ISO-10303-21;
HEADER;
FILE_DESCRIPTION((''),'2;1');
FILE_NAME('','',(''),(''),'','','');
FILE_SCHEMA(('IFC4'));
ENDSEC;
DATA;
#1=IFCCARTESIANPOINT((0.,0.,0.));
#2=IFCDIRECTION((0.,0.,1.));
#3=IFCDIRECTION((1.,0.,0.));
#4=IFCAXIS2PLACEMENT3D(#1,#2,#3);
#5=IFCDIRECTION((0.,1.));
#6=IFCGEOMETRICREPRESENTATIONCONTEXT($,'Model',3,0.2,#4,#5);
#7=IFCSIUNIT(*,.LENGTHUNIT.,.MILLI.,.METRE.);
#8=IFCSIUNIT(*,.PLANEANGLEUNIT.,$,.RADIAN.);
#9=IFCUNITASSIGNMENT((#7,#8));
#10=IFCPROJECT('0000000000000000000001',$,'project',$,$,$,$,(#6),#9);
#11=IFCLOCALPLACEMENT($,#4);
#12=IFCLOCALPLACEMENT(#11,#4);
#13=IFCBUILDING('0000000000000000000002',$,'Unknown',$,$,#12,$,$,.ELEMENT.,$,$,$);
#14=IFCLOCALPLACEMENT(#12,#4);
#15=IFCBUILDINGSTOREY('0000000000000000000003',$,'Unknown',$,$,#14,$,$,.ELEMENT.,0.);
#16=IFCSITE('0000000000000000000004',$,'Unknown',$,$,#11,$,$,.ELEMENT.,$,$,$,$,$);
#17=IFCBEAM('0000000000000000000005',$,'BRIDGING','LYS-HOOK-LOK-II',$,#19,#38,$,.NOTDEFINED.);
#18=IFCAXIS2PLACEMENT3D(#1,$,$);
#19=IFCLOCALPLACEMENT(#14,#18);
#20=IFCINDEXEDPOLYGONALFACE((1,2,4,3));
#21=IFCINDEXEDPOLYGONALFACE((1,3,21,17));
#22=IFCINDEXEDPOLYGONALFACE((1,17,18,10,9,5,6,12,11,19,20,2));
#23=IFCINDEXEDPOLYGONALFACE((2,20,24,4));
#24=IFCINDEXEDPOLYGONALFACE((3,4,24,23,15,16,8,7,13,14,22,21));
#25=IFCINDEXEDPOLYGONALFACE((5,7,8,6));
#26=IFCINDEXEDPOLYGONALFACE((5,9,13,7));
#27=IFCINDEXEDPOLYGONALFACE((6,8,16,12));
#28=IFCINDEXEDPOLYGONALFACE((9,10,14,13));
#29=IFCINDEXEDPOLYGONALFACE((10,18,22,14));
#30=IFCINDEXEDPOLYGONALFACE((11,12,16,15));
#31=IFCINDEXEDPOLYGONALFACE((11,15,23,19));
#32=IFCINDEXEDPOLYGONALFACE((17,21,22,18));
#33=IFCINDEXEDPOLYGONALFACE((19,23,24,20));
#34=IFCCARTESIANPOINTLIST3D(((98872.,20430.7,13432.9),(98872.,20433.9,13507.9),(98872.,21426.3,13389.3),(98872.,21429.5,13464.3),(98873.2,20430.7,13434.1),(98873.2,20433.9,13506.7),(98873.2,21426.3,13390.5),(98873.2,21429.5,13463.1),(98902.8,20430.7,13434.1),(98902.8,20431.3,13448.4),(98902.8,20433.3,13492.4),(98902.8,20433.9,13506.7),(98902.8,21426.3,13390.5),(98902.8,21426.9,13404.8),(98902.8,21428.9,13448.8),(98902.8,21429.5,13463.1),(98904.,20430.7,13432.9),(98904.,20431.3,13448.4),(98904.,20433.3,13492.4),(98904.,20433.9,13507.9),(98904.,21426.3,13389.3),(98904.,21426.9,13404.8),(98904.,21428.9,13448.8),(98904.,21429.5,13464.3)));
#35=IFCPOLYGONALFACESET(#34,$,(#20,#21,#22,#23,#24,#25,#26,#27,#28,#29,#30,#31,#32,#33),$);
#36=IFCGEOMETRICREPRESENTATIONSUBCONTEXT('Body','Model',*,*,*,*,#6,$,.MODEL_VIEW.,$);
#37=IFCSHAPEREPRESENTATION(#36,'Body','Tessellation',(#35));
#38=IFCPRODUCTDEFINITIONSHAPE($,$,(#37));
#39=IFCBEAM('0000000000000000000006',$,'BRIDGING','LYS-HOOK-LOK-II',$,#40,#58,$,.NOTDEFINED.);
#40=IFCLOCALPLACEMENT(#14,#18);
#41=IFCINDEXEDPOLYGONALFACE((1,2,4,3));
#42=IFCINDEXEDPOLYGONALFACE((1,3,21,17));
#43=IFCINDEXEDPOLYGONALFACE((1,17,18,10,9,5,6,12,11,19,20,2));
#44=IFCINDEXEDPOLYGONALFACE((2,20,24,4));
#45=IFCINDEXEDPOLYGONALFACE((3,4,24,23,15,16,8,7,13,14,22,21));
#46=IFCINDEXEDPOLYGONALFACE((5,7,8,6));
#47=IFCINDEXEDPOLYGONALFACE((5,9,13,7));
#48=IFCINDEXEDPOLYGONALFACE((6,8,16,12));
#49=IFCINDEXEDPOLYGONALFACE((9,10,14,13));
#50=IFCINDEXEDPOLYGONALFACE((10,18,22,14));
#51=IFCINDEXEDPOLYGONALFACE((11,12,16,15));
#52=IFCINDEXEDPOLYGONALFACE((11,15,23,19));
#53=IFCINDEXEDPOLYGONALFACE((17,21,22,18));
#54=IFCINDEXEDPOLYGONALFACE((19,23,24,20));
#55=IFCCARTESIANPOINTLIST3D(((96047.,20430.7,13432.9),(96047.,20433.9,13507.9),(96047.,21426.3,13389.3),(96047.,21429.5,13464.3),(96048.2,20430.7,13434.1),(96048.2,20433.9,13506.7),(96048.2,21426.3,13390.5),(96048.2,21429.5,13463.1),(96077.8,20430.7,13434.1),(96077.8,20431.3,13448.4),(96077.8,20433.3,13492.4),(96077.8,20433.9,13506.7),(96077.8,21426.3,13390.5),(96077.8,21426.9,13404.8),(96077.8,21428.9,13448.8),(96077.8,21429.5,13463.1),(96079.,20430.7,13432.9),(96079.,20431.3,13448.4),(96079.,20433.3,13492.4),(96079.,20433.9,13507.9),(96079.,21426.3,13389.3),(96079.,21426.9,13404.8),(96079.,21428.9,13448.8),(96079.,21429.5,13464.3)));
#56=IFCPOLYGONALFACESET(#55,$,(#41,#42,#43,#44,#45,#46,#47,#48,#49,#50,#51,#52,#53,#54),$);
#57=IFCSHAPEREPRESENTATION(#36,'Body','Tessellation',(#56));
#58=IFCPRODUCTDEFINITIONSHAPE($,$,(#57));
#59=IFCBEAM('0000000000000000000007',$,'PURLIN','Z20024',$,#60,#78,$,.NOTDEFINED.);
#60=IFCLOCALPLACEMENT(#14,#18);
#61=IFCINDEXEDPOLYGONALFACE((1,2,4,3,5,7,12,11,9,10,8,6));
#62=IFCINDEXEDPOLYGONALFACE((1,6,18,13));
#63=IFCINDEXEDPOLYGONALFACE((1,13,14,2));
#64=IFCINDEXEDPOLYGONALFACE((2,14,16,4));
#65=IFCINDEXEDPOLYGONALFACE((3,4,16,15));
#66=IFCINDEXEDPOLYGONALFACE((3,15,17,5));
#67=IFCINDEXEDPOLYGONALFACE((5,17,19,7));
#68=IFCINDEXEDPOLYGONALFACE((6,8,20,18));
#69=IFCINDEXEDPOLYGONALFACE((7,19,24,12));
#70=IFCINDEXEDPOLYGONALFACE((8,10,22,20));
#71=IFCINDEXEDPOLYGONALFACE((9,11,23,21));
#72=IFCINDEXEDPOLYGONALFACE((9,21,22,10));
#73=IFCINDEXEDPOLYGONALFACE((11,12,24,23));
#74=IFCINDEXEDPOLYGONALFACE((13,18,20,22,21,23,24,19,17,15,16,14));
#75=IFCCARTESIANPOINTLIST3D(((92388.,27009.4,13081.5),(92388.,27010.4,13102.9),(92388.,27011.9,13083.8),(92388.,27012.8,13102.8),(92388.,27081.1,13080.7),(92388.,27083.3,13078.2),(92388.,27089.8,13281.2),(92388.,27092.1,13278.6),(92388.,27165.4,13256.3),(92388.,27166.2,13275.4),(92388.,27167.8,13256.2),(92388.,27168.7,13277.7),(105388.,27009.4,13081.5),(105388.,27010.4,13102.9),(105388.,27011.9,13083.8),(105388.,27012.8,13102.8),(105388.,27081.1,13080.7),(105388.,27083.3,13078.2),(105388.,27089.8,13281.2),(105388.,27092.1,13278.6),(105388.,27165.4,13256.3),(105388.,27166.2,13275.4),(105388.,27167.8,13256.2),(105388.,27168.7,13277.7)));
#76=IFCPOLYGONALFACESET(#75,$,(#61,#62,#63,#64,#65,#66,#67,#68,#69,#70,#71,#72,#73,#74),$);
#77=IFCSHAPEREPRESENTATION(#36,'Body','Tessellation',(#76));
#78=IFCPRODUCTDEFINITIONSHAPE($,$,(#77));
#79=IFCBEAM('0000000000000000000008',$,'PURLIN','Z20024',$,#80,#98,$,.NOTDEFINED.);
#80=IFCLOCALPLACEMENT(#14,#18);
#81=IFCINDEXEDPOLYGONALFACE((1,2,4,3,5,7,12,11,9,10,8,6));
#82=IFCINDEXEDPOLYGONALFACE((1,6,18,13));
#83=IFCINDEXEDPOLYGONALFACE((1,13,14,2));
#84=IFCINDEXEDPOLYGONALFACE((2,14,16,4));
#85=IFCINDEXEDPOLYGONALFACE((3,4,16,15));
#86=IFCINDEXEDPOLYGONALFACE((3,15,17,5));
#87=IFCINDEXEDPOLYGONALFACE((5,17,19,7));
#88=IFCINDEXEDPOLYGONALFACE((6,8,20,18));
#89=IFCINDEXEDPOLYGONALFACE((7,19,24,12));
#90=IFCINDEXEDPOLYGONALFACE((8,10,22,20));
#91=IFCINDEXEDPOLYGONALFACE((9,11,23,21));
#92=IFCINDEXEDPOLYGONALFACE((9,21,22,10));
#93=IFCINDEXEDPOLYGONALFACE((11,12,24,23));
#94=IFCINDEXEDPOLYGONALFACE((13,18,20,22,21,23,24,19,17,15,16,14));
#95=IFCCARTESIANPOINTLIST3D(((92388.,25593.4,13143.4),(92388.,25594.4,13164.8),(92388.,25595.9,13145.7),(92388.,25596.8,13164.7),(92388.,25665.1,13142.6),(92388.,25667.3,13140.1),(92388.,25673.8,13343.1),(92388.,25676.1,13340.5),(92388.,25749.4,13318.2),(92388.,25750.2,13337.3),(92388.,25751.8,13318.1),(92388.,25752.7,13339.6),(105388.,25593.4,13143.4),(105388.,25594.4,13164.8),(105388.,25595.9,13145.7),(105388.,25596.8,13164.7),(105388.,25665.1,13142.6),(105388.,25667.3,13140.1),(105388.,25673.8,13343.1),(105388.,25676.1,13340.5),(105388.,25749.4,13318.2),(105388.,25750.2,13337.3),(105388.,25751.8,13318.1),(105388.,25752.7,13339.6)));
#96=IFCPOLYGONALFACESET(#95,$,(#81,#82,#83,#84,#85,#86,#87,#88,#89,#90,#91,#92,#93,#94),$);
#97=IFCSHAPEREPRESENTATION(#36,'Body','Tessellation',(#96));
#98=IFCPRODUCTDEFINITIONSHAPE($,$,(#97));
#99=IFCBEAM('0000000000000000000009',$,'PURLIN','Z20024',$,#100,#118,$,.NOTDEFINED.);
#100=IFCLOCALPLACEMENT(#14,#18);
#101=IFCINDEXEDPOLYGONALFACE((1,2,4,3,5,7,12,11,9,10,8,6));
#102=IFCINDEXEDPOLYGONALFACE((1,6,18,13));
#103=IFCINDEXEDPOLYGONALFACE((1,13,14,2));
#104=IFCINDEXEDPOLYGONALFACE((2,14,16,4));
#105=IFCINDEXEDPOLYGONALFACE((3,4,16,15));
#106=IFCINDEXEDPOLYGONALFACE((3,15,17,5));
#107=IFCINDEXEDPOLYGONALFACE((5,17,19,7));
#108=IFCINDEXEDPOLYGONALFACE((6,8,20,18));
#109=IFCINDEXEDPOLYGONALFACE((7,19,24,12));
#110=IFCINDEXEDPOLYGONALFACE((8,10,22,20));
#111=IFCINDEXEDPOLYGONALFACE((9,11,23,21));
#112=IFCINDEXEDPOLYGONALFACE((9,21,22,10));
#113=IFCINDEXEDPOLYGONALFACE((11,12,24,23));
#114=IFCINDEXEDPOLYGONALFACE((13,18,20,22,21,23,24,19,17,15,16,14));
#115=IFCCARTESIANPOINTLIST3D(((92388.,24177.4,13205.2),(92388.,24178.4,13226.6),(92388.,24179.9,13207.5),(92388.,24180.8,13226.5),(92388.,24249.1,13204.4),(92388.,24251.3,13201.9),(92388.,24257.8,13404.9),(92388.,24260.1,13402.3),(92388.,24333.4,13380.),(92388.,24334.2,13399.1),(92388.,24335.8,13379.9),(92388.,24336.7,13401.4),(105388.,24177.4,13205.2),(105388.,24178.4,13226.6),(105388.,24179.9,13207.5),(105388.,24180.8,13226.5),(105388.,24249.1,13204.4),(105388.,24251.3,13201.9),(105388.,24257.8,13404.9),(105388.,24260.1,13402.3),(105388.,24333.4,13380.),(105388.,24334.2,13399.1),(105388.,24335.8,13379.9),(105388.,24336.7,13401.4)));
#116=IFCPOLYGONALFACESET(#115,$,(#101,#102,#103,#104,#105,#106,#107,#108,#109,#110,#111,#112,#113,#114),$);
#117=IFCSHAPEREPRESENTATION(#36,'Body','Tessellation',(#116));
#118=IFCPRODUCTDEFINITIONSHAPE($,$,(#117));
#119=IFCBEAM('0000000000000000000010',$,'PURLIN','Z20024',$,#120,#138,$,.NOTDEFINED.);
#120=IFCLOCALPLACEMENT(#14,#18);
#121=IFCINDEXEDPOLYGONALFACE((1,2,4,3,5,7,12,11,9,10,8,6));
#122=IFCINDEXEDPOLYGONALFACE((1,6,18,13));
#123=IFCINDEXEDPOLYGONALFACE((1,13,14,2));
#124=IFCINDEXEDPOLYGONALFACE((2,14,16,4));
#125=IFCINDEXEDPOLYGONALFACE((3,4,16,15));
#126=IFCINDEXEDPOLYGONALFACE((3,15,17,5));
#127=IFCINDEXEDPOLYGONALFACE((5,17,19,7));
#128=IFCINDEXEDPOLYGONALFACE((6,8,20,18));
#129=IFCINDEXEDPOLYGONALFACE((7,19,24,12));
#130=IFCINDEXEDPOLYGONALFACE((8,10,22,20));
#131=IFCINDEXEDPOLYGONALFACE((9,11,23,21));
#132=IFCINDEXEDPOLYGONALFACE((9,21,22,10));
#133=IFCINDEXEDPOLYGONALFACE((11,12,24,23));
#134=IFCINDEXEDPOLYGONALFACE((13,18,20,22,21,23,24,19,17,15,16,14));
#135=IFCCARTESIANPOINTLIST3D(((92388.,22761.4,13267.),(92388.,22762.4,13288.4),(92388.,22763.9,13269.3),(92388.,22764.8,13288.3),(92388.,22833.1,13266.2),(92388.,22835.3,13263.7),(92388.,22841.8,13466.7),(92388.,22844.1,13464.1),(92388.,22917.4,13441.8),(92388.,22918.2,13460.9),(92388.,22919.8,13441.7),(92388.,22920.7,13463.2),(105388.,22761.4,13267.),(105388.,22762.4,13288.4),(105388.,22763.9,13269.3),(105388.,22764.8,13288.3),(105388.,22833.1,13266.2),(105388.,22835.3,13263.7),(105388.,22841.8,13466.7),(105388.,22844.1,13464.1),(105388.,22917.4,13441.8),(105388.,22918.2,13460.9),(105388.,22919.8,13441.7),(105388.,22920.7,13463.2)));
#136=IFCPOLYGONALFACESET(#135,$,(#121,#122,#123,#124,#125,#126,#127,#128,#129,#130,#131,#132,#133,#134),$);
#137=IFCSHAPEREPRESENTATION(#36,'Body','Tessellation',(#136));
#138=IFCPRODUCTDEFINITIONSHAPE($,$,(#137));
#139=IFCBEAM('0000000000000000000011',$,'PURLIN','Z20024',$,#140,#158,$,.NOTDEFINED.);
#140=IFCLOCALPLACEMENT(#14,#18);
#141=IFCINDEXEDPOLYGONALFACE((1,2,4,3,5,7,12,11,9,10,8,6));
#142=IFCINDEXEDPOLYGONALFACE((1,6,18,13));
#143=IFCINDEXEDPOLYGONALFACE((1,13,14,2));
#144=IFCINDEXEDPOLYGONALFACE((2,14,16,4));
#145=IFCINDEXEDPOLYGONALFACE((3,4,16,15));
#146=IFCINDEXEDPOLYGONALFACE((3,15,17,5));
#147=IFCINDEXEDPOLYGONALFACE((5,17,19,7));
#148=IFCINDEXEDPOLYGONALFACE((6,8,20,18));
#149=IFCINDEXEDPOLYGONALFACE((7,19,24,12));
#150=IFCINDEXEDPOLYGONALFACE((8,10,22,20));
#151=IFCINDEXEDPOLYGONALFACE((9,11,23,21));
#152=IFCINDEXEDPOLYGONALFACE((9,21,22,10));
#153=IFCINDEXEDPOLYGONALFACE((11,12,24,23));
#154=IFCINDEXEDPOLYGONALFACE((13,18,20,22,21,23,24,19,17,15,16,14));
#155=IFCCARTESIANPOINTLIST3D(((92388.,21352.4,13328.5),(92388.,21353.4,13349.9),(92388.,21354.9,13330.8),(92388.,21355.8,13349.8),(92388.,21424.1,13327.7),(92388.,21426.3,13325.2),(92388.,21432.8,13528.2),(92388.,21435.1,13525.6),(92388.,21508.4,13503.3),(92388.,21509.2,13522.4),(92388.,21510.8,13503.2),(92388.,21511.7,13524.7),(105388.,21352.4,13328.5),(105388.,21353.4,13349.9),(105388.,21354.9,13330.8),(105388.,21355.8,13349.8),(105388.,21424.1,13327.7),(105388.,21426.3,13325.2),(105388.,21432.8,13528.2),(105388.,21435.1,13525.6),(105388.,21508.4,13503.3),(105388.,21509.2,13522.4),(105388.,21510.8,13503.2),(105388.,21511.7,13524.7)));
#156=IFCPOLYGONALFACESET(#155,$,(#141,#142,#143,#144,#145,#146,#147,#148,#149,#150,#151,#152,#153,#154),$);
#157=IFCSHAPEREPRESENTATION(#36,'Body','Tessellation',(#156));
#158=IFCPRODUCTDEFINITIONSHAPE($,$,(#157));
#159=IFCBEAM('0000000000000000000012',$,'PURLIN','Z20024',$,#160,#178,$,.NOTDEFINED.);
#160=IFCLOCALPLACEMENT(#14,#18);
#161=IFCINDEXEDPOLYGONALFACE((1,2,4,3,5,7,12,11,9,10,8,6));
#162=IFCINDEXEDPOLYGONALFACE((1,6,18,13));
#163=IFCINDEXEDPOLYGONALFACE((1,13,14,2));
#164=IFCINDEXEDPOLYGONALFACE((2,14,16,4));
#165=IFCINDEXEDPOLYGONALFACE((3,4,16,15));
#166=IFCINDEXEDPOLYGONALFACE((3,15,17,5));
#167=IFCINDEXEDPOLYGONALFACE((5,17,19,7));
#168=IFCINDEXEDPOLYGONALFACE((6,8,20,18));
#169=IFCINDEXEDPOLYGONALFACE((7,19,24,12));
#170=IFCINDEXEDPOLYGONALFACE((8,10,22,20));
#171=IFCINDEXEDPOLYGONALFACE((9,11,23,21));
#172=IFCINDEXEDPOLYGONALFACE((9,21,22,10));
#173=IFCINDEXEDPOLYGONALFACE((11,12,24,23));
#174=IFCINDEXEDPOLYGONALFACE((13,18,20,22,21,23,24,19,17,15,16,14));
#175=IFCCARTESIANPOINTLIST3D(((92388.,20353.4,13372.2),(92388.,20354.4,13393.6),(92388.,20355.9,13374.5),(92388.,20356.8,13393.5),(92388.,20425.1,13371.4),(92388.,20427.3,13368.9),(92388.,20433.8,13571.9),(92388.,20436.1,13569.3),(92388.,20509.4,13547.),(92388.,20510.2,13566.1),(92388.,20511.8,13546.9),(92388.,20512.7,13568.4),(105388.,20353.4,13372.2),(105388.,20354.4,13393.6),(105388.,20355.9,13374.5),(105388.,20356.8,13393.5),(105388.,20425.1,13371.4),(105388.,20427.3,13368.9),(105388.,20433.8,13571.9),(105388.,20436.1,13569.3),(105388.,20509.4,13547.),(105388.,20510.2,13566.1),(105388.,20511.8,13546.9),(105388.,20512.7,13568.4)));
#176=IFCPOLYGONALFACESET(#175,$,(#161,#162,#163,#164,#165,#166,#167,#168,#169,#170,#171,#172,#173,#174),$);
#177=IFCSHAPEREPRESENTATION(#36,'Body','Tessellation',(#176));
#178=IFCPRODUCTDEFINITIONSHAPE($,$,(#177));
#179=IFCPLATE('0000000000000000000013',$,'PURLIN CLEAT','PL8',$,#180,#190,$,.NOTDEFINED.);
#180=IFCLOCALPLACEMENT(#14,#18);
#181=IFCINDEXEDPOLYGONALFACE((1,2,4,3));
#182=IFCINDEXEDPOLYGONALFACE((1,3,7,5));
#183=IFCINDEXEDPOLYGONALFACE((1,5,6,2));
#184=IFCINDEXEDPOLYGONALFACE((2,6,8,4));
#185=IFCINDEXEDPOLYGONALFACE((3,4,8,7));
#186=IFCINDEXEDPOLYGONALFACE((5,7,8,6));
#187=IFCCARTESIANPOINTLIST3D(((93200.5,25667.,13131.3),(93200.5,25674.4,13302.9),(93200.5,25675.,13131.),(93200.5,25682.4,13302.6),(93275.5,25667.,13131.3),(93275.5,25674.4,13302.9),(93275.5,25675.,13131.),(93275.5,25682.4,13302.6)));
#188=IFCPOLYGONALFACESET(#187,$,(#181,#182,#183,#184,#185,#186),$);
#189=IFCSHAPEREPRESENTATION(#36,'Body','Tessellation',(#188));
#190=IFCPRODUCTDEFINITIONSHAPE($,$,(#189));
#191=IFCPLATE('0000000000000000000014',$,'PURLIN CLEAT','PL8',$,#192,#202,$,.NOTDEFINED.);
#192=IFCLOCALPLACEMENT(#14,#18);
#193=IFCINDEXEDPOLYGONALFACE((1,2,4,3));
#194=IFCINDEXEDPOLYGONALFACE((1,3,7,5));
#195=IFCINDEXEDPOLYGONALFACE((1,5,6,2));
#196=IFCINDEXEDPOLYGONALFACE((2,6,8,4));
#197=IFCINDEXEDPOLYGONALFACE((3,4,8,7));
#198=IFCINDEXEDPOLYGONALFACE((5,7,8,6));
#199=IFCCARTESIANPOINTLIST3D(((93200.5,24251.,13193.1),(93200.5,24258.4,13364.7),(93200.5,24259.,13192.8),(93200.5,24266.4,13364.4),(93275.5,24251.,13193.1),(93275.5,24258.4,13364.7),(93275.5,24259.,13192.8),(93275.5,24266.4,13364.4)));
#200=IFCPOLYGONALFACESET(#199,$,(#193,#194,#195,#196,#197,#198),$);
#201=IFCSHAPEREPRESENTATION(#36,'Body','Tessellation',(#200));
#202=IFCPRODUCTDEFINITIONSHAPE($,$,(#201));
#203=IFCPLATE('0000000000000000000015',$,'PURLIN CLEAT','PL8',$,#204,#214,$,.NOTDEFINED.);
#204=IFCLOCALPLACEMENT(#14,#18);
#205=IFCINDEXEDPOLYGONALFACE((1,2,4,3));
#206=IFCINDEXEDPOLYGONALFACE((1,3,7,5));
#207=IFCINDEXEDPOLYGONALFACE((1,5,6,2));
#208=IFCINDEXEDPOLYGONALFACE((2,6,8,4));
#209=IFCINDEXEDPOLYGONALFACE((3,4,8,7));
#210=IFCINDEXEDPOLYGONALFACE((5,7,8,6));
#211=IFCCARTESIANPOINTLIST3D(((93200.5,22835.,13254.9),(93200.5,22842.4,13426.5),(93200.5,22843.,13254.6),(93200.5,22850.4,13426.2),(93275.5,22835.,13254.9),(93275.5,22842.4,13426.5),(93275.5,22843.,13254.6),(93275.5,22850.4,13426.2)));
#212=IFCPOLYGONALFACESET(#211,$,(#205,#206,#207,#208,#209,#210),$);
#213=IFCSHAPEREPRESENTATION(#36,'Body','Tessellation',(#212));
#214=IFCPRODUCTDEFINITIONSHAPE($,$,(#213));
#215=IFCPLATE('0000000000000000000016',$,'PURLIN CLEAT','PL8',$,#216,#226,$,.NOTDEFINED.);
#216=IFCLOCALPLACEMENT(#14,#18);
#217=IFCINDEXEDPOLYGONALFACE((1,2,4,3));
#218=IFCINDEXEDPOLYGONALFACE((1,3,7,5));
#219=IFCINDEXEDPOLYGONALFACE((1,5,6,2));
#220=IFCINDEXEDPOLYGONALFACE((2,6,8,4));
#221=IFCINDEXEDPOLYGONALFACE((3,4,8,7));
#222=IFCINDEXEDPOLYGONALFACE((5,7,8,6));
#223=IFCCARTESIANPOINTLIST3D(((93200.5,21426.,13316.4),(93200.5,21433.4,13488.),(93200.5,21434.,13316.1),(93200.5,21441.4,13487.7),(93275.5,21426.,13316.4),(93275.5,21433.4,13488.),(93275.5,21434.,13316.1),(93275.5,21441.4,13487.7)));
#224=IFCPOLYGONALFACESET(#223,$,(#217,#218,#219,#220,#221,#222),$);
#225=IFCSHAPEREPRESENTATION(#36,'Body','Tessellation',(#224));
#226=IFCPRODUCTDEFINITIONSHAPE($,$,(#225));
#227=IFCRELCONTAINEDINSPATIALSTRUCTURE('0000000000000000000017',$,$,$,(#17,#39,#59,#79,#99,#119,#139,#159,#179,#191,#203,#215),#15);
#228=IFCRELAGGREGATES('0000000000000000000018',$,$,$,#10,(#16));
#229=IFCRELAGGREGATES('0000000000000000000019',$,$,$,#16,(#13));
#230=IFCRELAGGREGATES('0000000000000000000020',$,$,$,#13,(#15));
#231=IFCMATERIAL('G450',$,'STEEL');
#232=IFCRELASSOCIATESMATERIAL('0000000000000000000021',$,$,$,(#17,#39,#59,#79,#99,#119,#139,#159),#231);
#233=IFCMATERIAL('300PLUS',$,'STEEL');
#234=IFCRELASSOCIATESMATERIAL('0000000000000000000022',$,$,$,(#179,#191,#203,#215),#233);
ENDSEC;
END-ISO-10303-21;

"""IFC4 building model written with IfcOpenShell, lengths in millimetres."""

from ifc_helpers import new_model, si_unit, direction, frame, origin_with_axes, place, context, subcontext, project, spatial, line, indexed_curve, outline, extrude, material, element, save


model = new_model("IFC4")

# Units and contexts
model_context = context("Model", 3, precision=0.2, world=origin_with_axes(), true_north=direction((0.0, 1.0)))
body_context = subcontext(model_context, "Body", "Model", "MODEL_VIEW")
ifc_project = project(units=[si_unit("LENGTHUNIT", "METRE", prefix="MILLI"), si_unit("PLANEANGLEUNIT", "RADIAN")], contexts=[model_context])

# Site, building, storey
site_placement = place(None, origin_with_axes())
site = spatial("IfcSite", under=ifc_project, at=site_placement, Name="Unknown", CompositionType="ELEMENT")
building_placement = place(site_placement, origin_with_axes())
building = spatial("IfcBuilding", under=site, at=building_placement, Name="Unknown", CompositionType="ELEMENT")
storey_placement = place(building_placement, origin_with_axes())
storey = spatial("IfcBuildingStorey", under=building, at=storey_placement, Name="Unknown", CompositionType="ELEMENT", Elevation=0.0)

# Beams
ifc_material_1 = material(Name="G450", Category="STEEL")
for number, where, z_axis, x_axis, name in (
    (1, (98888.0, 20432.3, 13470.4), (1.0, 0.0, 0.0), (0.0, 0.999042, -0.043751), "BRIDGING"),
    (2, (96063.0, 20432.3, 13470.4), (1.0, 0.0, 0.0), (0.0, 0.999042, -0.043751), "BRIDGING"),
):
    element("IfcBeam", number, at=place(storey_placement, frame(where, z_axis=z_axis, x_axis=x_axis)), inside=storey, material=ifc_material_1, Name=name, Description="LYS-HOOK-LOK-II", PredefinedType="NOTDEFINED", context=body_context, shape_type="SolidModel", body=[
        extrude(outline(indexed_curve([(16.0, -37.5), (16.0, -22.0), (14.8, -22.0), (14.8, -36.3), (-14.8, -36.3), (-14.8, 36.3), (14.8, 36.3), (14.8, 22.0), (16.0, 22.0), (16.0, 37.5), (-16.0, 37.5), (-16.0, -37.5)], segments=[line(1, 2, 3, 4, 5, 6, 7, 8, 9, 10, 11, 12, 1)])), frame((0.0, 0.0, 0.0), z_axis=(-1.0, 0.0, 0.0), x_axis=(0.0, 0.0, 1.0)), (0.0, 0.0, -1.0), 996.6),
    ])
for number, where, z_axis, x_axis, name in (
    (3, (92388.0, 27086.6, 13179.7), (0.0, -0.999048, 0.043619), (1.0, 0.0, 0.0), "PURLIN"),
    (4, (92388.0, 25670.6, 13241.6), (0.0, -0.999048, 0.043619), (1.0, 0.0, 0.0), "PURLIN"),
    (5, (92388.0, 24254.6, 13303.4), (0.0, -0.999048, 0.043619), (1.0, 0.0, 0.0), "PURLIN"),
    (6, (92388.0, 22838.6, 13365.2), (0.0, -0.999048, 0.043619), (1.0, 0.0, 0.0), "PURLIN"),
    (7, (92388.0, 21429.6, 13426.7), (0.0, -0.999048, 0.043619), (1.0, 0.0, 0.0), "PURLIN"),
    (8, (92388.0, 20430.6, 13470.4), (0.0, -0.999048, 0.043619), (1.0, 0.0, 0.0), "PURLIN"),
):
    element("IfcBeam", number, at=place(storey_placement, frame(where, z_axis=z_axis, x_axis=x_axis)), inside=storey, material=ifc_material_1, Name=name, Description="Z20024", PredefinedType="NOTDEFINED", context=body_context, shape_type="SolidModel", body=[
        extrude(outline(indexed_curve([(72.8, -101.5), (72.8, -80.0), (70.4, -80.0), (70.4, -99.1), (1.2, -99.1), (1.2, 101.5), (-77.8, 101.5), (-77.8, 80.0), (-75.4, 80.0), (-75.4, 99.1), (-1.2, 99.1), (-1.2, -101.5)], segments=[line(1, 2, 3, 4, 5, 6, 7, 8, 9, 10, 11, 12, 1)])), frame((0.0, 0.0, 0.0), z_axis=(-1.0, 0.0, 0.0), x_axis=(0.0, 0.0, 1.0)), (0.0, 0.0, -1.0), 13000.0),
    ])

# Plates
ifc_material_2 = material(Name="300PLUS", Category="STEEL")
for number, where, z_axis, x_axis, name in (
    (9, (93200.5, 25671.0, 13131.2), (0.0, -0.999071, 0.043084), (1.0, 0.0, 0.0), "PURLIN CLEAT"),
    (10, (93200.5, 24255.0, 13193.0), (0.0, -0.999071, 0.043084), (1.0, 0.0, 0.0), "PURLIN CLEAT"),
    (11, (93200.5, 22839.0, 13254.8), (0.0, -0.999071, 0.043084), (1.0, 0.0, 0.0), "PURLIN CLEAT"),
    (12, (93200.5, 21430.0, 13316.3), (0.0, -0.999071, 0.043084), (1.0, 0.0, 0.0), "PURLIN CLEAT"),
):
    element("IfcPlate", number, at=place(storey_placement, frame(where, z_axis=z_axis, x_axis=x_axis)), inside=storey, material=ifc_material_2, Name=name, Description="PL8", PredefinedType="NOTDEFINED", context=body_context, shape_type="SolidModel", body=[
        extrude(outline(indexed_curve([(0.0, 0.0), (75.0, 0.0), (75.0, 171.8), (0.0, 171.8)], segments=[line(1, 2, 3, 4, 1)])), frame((0.0, 0.0, 4.0), z_axis=(0.0, 0.0, 1.0), x_axis=(1.0, 0.0, 0.0)), (0.0, 0.0, -1.0), 8.0),
    ])

save(model, "model.ifc")
